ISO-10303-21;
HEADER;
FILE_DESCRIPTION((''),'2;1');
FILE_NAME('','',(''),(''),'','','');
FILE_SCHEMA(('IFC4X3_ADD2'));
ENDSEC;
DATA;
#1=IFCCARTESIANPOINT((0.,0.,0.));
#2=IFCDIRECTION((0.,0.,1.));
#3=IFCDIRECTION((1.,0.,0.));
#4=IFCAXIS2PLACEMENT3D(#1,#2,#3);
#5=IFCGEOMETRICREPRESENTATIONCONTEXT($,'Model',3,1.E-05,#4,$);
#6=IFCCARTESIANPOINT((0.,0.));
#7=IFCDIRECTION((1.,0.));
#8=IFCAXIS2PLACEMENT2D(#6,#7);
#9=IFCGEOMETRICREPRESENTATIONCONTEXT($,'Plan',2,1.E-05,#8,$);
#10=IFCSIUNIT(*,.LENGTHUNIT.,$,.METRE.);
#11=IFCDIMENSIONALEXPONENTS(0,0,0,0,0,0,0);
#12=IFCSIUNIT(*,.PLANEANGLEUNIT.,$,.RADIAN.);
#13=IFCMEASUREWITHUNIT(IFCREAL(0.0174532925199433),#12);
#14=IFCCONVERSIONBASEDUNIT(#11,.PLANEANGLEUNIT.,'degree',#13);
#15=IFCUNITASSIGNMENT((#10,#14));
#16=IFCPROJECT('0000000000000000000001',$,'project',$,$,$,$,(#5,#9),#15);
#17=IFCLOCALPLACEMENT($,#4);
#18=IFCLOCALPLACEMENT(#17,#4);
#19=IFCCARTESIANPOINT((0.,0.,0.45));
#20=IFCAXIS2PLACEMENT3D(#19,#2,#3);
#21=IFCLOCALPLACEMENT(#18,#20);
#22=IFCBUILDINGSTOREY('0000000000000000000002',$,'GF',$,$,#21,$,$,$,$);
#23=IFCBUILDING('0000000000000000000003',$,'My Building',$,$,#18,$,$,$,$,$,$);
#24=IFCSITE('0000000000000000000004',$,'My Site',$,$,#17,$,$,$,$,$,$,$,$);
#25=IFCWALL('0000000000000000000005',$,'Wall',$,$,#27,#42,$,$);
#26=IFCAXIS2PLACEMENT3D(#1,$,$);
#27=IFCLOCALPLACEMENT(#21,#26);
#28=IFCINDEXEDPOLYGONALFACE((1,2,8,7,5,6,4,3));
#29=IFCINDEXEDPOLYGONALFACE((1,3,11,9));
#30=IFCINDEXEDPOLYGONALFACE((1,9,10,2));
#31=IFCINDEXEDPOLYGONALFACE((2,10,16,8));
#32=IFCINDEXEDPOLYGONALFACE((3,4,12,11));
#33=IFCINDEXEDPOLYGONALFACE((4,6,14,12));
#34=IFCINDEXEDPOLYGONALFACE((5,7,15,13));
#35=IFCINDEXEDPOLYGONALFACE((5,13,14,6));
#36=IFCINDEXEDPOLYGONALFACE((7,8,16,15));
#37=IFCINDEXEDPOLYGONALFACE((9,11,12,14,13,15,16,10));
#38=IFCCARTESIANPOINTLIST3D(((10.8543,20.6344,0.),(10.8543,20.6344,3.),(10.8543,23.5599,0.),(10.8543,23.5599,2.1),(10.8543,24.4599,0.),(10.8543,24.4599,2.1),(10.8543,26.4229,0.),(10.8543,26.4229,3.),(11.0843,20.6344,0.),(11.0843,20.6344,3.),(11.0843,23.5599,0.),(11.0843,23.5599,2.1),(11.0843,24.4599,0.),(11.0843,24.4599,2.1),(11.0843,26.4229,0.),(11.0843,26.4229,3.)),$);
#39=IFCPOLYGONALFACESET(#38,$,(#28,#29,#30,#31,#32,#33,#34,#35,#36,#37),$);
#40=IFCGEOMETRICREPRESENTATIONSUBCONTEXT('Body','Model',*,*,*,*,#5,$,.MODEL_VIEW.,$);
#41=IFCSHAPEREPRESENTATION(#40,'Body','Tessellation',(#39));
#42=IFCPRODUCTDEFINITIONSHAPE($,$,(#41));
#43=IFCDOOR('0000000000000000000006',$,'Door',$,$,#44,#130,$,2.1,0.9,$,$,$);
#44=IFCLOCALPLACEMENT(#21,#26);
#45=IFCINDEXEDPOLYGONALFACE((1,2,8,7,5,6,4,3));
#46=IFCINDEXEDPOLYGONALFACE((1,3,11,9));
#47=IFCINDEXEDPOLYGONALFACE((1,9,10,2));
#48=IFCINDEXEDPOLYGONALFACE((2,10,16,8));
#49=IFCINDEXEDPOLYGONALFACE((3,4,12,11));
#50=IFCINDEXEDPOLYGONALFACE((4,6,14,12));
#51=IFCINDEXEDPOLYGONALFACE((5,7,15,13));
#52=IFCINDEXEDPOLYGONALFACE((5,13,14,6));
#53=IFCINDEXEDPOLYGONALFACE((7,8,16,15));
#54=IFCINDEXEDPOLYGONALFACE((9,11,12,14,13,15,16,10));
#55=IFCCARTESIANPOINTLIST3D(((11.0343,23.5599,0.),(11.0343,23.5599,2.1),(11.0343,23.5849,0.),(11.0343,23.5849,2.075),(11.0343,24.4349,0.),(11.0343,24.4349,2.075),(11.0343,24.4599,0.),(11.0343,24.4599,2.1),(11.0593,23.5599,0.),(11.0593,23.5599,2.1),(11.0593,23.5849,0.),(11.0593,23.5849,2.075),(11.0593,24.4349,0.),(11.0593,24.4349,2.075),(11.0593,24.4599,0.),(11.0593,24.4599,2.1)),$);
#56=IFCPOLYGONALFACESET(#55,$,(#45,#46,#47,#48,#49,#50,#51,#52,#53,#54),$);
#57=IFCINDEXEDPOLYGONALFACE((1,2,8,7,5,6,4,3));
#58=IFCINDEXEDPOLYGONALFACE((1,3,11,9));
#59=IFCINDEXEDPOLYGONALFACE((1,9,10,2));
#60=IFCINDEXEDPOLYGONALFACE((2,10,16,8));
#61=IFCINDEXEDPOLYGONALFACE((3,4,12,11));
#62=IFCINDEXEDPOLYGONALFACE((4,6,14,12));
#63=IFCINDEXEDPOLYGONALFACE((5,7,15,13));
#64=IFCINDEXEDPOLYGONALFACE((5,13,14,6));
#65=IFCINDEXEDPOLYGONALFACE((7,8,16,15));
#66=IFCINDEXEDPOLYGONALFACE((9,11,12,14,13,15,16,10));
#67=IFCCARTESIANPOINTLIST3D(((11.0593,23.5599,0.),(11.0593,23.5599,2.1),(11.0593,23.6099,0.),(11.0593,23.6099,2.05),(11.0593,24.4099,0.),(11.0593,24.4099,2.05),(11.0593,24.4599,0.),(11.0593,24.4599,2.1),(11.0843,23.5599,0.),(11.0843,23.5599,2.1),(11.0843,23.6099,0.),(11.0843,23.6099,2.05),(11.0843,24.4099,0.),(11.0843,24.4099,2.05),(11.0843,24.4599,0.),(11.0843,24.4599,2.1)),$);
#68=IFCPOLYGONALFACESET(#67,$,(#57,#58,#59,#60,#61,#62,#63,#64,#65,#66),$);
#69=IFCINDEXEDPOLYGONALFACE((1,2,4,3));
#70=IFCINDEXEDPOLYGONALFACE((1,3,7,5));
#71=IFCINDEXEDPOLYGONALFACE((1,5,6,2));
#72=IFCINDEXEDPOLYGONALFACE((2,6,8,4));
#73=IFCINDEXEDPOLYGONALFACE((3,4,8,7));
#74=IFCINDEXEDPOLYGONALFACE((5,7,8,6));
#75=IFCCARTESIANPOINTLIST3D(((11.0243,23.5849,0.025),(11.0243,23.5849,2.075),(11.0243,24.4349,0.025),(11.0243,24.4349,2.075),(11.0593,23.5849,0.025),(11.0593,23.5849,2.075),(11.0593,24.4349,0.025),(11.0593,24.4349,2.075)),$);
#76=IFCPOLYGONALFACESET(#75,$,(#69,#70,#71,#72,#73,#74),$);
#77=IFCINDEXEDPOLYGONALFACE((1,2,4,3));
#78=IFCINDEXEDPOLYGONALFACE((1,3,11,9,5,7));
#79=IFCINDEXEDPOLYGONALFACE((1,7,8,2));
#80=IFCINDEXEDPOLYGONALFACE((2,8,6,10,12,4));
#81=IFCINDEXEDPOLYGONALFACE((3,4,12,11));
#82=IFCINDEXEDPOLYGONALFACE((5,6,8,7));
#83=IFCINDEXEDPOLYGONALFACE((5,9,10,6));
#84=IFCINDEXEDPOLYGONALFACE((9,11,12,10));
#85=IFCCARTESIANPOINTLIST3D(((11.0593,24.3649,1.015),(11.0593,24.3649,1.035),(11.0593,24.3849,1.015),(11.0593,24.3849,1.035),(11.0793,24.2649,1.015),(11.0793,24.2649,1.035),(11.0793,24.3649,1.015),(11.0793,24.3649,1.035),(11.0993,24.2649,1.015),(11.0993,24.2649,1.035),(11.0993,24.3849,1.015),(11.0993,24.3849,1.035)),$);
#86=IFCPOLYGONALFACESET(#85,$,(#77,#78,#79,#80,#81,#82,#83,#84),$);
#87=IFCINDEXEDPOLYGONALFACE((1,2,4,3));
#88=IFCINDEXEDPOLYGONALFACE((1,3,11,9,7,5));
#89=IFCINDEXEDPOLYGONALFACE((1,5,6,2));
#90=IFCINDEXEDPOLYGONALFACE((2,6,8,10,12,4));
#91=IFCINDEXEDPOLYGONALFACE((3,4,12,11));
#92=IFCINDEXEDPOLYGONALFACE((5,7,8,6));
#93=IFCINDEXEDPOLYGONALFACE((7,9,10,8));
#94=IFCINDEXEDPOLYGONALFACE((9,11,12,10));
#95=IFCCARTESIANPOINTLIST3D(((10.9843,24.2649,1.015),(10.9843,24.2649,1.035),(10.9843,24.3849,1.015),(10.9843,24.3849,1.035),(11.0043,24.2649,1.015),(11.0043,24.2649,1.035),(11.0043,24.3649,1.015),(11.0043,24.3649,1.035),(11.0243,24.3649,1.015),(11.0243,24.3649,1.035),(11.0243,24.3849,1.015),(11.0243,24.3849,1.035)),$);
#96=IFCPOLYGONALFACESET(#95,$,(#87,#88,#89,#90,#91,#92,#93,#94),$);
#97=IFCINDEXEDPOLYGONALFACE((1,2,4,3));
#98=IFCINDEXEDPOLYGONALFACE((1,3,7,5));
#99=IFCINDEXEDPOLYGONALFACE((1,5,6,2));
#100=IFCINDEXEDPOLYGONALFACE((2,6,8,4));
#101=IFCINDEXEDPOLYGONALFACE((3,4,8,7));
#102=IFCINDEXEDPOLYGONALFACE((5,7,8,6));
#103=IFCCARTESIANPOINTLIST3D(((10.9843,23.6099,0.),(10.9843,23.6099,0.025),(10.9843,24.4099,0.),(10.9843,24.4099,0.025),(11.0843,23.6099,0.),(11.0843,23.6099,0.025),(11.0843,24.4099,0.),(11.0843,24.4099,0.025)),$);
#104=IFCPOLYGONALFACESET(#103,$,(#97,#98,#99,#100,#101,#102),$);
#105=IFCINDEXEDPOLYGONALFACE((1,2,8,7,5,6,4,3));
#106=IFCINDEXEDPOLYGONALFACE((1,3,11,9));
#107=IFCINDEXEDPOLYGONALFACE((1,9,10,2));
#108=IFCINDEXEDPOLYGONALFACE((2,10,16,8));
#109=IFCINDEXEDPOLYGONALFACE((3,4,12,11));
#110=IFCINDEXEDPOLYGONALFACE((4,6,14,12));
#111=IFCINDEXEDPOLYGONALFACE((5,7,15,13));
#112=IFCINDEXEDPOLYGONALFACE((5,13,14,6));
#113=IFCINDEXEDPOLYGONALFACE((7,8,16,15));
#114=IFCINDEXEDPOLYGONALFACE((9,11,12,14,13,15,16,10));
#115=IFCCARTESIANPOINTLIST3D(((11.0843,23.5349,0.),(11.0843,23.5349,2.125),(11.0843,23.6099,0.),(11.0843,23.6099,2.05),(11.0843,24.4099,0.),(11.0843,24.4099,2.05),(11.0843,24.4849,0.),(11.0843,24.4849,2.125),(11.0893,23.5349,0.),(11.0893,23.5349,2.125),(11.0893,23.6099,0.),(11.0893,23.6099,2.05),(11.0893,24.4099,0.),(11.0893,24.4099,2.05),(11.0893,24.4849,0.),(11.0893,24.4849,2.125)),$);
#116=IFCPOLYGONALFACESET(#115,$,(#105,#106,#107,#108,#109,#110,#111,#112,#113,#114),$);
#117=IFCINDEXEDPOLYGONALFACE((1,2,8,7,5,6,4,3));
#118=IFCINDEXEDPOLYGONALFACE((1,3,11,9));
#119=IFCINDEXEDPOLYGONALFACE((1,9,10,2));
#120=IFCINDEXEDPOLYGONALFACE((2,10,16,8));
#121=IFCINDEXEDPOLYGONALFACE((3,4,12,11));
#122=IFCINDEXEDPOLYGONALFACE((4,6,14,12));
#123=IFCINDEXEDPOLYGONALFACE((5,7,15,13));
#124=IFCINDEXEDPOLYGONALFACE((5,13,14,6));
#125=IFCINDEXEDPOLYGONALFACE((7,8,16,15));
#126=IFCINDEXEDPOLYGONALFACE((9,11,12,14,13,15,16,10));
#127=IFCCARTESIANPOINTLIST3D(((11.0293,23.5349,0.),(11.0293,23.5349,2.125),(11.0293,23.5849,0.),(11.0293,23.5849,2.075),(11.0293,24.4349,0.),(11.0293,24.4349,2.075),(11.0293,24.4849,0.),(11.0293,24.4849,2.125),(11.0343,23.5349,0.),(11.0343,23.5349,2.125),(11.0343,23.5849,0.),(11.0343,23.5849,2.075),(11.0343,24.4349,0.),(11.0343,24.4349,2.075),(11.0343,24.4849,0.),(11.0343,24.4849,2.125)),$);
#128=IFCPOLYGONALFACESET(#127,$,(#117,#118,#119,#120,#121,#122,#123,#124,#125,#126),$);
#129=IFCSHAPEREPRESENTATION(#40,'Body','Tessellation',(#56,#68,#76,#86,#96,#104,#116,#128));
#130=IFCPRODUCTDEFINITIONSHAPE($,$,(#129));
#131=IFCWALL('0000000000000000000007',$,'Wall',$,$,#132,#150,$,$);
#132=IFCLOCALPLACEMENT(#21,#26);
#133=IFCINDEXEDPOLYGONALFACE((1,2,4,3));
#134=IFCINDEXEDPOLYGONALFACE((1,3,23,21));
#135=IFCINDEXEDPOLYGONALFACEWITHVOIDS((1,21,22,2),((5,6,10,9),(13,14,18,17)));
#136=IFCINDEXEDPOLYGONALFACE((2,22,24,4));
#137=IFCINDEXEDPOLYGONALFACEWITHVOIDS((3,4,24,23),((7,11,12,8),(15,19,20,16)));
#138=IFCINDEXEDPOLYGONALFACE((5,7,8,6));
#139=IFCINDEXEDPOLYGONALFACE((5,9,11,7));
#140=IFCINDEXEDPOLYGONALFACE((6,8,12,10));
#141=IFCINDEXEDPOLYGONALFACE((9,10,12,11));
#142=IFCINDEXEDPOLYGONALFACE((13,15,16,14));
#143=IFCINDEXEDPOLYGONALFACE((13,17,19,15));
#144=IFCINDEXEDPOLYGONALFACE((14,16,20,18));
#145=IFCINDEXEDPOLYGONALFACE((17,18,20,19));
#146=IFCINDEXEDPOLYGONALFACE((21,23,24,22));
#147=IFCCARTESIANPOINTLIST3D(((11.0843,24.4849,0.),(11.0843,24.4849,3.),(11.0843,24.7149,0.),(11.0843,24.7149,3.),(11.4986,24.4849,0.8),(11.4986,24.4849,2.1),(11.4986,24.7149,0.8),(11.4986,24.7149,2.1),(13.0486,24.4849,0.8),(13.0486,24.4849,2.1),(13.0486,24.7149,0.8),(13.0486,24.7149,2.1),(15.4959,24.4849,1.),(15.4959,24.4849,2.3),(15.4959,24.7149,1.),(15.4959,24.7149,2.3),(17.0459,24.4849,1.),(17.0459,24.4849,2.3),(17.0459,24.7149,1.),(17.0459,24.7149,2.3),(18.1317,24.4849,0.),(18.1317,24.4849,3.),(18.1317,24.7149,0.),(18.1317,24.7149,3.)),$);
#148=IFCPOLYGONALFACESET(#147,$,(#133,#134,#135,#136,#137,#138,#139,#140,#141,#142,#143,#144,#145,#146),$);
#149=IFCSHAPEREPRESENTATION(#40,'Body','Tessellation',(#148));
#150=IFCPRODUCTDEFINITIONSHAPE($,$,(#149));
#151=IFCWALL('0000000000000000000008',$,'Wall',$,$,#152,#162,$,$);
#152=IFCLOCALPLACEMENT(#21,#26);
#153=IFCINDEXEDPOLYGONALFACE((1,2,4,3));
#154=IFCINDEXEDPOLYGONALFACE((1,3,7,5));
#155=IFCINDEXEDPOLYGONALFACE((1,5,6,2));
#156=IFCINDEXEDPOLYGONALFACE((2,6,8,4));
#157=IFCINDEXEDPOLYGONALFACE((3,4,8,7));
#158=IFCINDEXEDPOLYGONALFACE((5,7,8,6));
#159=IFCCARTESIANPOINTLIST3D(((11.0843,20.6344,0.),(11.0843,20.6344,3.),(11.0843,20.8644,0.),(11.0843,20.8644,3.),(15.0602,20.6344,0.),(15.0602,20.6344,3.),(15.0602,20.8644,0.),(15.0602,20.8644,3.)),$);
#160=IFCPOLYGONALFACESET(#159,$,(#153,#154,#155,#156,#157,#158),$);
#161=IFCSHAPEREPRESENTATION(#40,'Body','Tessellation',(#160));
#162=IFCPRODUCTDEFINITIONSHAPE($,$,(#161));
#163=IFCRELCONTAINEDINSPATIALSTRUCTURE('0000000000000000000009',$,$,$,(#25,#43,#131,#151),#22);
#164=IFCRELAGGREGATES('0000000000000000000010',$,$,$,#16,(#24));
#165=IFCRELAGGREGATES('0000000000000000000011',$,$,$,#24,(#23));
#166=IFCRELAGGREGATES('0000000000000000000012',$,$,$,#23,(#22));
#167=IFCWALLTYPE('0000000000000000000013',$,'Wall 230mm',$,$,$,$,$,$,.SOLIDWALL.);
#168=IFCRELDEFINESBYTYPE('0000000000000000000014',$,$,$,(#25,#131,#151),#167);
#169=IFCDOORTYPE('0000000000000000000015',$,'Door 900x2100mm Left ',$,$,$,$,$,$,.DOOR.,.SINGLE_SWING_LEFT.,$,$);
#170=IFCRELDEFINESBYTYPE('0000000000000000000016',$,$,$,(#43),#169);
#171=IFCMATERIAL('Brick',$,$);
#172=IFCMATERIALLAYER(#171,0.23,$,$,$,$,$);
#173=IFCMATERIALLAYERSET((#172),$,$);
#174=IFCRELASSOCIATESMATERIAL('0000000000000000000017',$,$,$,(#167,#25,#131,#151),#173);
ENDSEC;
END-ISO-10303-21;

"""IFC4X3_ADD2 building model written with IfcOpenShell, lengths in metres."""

from ifc_helpers import new_model, entity, si_unit, converted_unit, frame, origin_with_axes, origin_2d_with_axis, place, context, subcontext, project, spatial, line, indexed_curve, outline, extrude, shape, source, transform, mapped, material, layer, layer_set, layer_usage, type_object, type_shapes, element, fill, save


model = new_model("IFC4X3_ADD2")

# Units and contexts
model_context = context("Model", 3, precision=1e-05, world=origin_with_axes())
plan_context = context("Plan", 2, precision=1e-05, world=origin_2d_with_axis())
body_context_1 = subcontext(model_context, "Body", "Model", "MODEL_VIEW")
body_context_2 = subcontext(plan_context, "Body", "Plan", "PLAN_VIEW")
ifc_project = project(units=[si_unit("LENGTHUNIT", "METRE"), converted_unit("PLANEANGLEUNIT", "degree", entity("IfcReal", 0.0174532925199433), si_unit("PLANEANGLEUNIT", "RADIAN"), dimensions=[0, 0, 0, 0, 0, 0, 0])], contexts=[model_context, plan_context])

# Site, building, storey
site_placement = place(None, origin_with_axes())
site = spatial("IfcSite", under=ifc_project, at=site_placement, Name="My Site")
building_placement = place(site_placement, origin_with_axes())
building = spatial("IfcBuilding", under=site, at=building_placement, Name="My Building")
storey_placement = place(building_placement, frame((0.0, 0.0, 0.45), z_axis=(0.0, 0.0, 1.0), x_axis=(1.0, 0.0, 0.0)))
storey = spatial("IfcBuildingStorey", under=building, at=storey_placement, Name="GF")

# Shared definitions
ifc_material = material(Name="Brick")
ifc_layer_1 = layer(ifc_material, 0.23)
ifc_layer_set_1 = layer_set([ifc_layer_1])
wall_type_1 = type_object("IfcWallType", Name="Wall 230mm", PredefinedType="SOLIDWALL", material=ifc_layer_set_1)

# Shared definitions
shared_shape_1 = source(origin_with_axes(), body_context_1, "Body", "SweptSolid", [
    extrude(outline(indexed_curve([(0.0, 0.0), (1.55, 0.0), (1.55, 1.3), (0.0, 1.3)], segments=[line(1, 2, 3, 4, 1)])), frame((-0.775, -0.6, 0.0), z_axis=(0.0, -1.0, 0.0), x_axis=(1.0, 0.0, 0.0)), (0.0, 0.0, -1.0), 1.2),
])

# Wall, opening, door
ifc_layer_usage_1 = layer_usage(ifc_layer_set_1, "AXIS2", "POSITIVE", 0.0)
wall_1_placement = place(storey_placement, frame((11.0843, 20.6344, 0.0), z_axis=(0.0, 0.0, 1.0), x_axis=(0.0, 1.0, 0.0)))
wall_1 = element("IfcWall", 1, at=wall_1_placement, inside=storey, type_object=wall_type_1, material=ifc_layer_usage_1, Name="Wall", context=body_context_1, shape_type="SweptSolid", body=[
    extrude(outline(indexed_curve([(0.0, 0.0), (0.0, 0.23), (5.7885, 0.23), (5.7885, 0.0), (0.0, 0.0)], self_intersect=False)), origin_with_axes(), (0.0, 0.0, 1.0), 3.0),
])
shared_shape_2 = source(origin_with_axes(), body_context_1, "Body", "SweptSolid", [
    extrude(outline(indexed_curve([(0.0, 0.0), (0.9, 0.0), (0.9, 2.1), (0.0, 2.1)], segments=[line(1, 2, 3, 4, 1)])), frame((0.0, -0.6, 0.0), z_axis=(0.0, -1.0, 0.0), x_axis=(1.0, 0.0, 0.0)), (0.0, 0.0, -1.0), 1.2),
])
opening_1_placement = place(wall_1_placement, frame((2.9255, 0.0, 0.0), z_axis=(0.0, 0.0, 1.0), x_axis=(1.0, 0.0, 0.0)))
opening_1 = element("IfcOpeningElement", 2, at=opening_1_placement, cuts=wall_1, PredefinedType="OPENING", context=body_context_1, shape_type="MappedRepresentation", body=[
    mapped(shared_shape_2, transform((0.0, 0.0, 0.0), x_axis=(1.0, 0.0, 0.0), y_axis=(0.0, 1.0, 0.0), z_axis=(0.0, 0.0, 1.0), scale=1.0)),
])
door_type_1 = type_object("IfcDoorType", Name="Door 900x2100mm Left ", OperationType="SINGLE_SWING_LEFT", PredefinedType="DOOR")
shared_shape_3 = source(origin_with_axes(), body_context_1, "Body", "SweptSolid", [
    extrude(outline(indexed_curve([(0.0, 0.0), (0.0, 2.1), (0.9, 2.1), (0.9, 0.0), (0.875, 0.0), (0.875, 2.075), (0.025, 2.075), (0.025, 0.0)], segments=[line(1, 2, 3, 4, 5, 6, 7, 8, 1)])), frame((0.0, 0.025, 0.0), z_axis=(0.0, -1.0, 0.0), x_axis=(1.0, 0.0, 0.0)), (0.0, 0.0, -1.0), 0.025),
    extrude(outline(indexed_curve([(0.0, 0.0), (0.0, 2.1), (0.9, 2.1), (0.9, 0.0), (0.85, 0.0), (0.85, 2.05), (0.05, 2.05), (0.05, 0.0)], segments=[line(1, 2, 3, 4, 5, 6, 7, 8, 1)])), frame((0.0, 0.0, 0.0), z_axis=(0.0, -1.0, 0.0), x_axis=(1.0, 0.0, 0.0)), (0.0, 0.0, -1.0), 0.025),
    extrude(outline(indexed_curve([(0.0, 0.0), (0.85, 0.0), (0.85, 0.035), (0.0, 0.035)], segments=[line(1, 2, 3, 4, 1)])), frame((0.025, 0.025, 0.025), z_axis=(0.0, 0.0, 1.0), x_axis=(1.0, 0.0, 0.0)), (0.0, 0.0, 1.0), 2.05),
    extrude(outline(indexed_curve([(0.0, 0.0), (0.0, -0.04), (-0.12, -0.04), (-0.12, -0.02), (-0.02, -0.02), (-0.02, 0.0)], segments=[line(1, 2, 3, 4, 5, 6, 1)])), frame((0.825, 0.025, 1.015), z_axis=(0.0, 0.0, 1.0), x_axis=(1.0, 0.0, 0.0)), (0.0, 0.0, 1.0), 0.02),
    extrude(outline(indexed_curve([(0.0, 0.0), (0.0, 0.04), (-0.12, 0.04), (-0.12, 0.02), (-0.02, 0.02), (-0.02, 0.0)], segments=[line(1, 2, 3, 4, 5, 6, 1)])), frame((0.825, 0.06, 1.015), z_axis=(0.0, 0.0, 1.0), x_axis=(1.0, 0.0, 0.0)), (0.0, 0.0, 1.0), 0.02),
    extrude(outline(indexed_curve([(0.0, 0.0), (0.8, 0.0), (0.8, 0.1), (0.0, 0.1)], segments=[line(1, 2, 3, 4, 1)])), frame((0.05, 0.0, 0.0), z_axis=(0.0, 0.0, 1.0), x_axis=(1.0, 0.0, 0.0)), (0.0, 0.0, 1.0), 0.025),
    extrude(outline(indexed_curve([(0.0, 0.0), (0.0, 2.125), (0.95, 2.125), (0.95, 0.0), (0.875, 0.0), (0.875, 2.05), (0.075, 2.05), (0.075, 0.0)], segments=[line(1, 2, 3, 4, 5, 6, 7, 8, 1)])), frame((-0.025, -0.005, 0.0), z_axis=(0.0, -1.0, 0.0), x_axis=(1.0, 0.0, 0.0)), (0.0, 0.0, -1.0), 0.005),
    extrude(outline(indexed_curve([(0.0, 0.0), (0.0, 2.125), (0.95, 2.125), (0.95, 0.0), (0.9, 0.0), (0.9, 2.075), (0.05, 2.075), (0.05, 0.0)], segments=[line(1, 2, 3, 4, 5, 6, 7, 8, 1)])), frame((-0.025, 0.05, 0.0), z_axis=(0.0, -1.0, 0.0), x_axis=(1.0, 0.0, 0.0)), (0.0, 0.0, -1.0), 0.005),
])
shared_shape_4 = source(origin_with_axes(), body_context_2, "Body", "Curve2D", [
    entity("IfcIndexedPolyCurve", entity("IfcCartesianPointList2D", [[0.0, 0.0], [0.0, 0.05], [0.025, 0.05], [0.025, 0.025], [0.05, 0.025], [0.05, 0.0]]), [entity("IfcLineIndex", [1, 2, 3, 4, 5, 6, 1])]),
    entity("IfcIndexedPolyCurve", entity("IfcCartesianPointList2D", [[0.9, 0.0], [0.9, 0.05], [0.875, 0.05], [0.875, 0.025], [0.85, 0.025], [0.85, 0.0]]), [entity("IfcLineIndex", [1, 2, 3, 4, 5, 6, 1])]),
    entity("IfcTrimmedCurve", entity("IfcEllipse", entity("IfcAxis2Placement2D", entity("IfcCartesianPoint", [0.06, 0.05]), entity("IfcDirection", [1.0, 0.0])), 0.815, 0.85), [entity("IfcCartesianPoint", [0.875, 0.05])], [entity("IfcCartesianPoint", [0.06, 0.9])], True, "CARTESIAN"),
    entity("IfcIndexedPolyCurve", entity("IfcCartesianPointList2D", [[0.025, 0.05], [0.06, 0.05], [0.06, 0.9], [0.025, 0.9]]), [entity("IfcLineIndex", [1, 2, 3, 4, 1])]),
])
type_shapes(door_type_1, [shared_shape_3, shared_shape_4])
door_1_placement = place(opening_1_placement, origin_with_axes())
door_1 = element("IfcDoor", 3, at=door_1_placement, inside=storey, type_object=door_type_1, Name="Door", OverallHeight=2.1, OverallWidth=0.9, shapes=[
    shape(body_context_1, "Body", "MappedRepresentation", [mapped(shared_shape_3, transform((0.0, 0.0, 0.0), x_axis=(1.0, 0.0, 0.0), y_axis=(0.0, 1.0, 0.0), z_axis=(0.0, 0.0, 1.0), scale=1.0))]),
    shape(body_context_2, "Body", "MappedRepresentation", [mapped(shared_shape_4, transform((0.0, 0.0, 0.0), x_axis=(1.0, 0.0, 0.0), y_axis=(0.0, 1.0, 0.0), z_axis=(0.0, 0.0, 1.0), scale=1.0))]),
])
fill(opening_1, door_1)

# Wall, openings
ifc_layer_usage_2 = layer_usage(ifc_layer_set_1, "AXIS2", "POSITIVE", 0.0)
wall_2_placement = place(storey_placement, frame((11.0843, 24.4849, 0.0), z_axis=(0.0, 0.0, 1.0), x_axis=(1.0, 0.0, 0.0)))
wall_2 = element("IfcWall", 4, at=wall_2_placement, inside=storey, type_object=wall_type_1, material=ifc_layer_usage_2, Name="Wall", context=body_context_1, shape_type="SweptSolid", body=[
    extrude(outline(indexed_curve([(0.0, 0.0), (0.0, 0.23), (7.0474, 0.23), (7.0474, 0.0), (0.0, 0.0)], self_intersect=False)), origin_with_axes(), (0.0, 0.0, 1.0), 3.0),
])
opening_2_placement = place(wall_2_placement, frame((5.1866, 0.2, 1.0), z_axis=(0.0, 0.0, 1.0), x_axis=(-1.0, 0.0, 0.0)))
element("IfcOpeningElement", 5, at=opening_2_placement, cuts=wall_2, PredefinedType="OPENING", context=body_context_1, shape_type="MappedRepresentation", body=[
    mapped(shared_shape_1, transform((0.0, 0.0, 0.0), x_axis=(1.0, 0.0, 0.0), y_axis=(0.0, 1.0, 0.0), z_axis=(0.0, 0.0, 1.0), scale=1.0)),
])
opening_3_placement = place(wall_2_placement, frame((1.1893, 0.0, 0.8), z_axis=(0.0, 0.0, 1.0), x_axis=(1.0, 0.0, 0.0)))
element("IfcOpeningElement", 6, at=opening_3_placement, cuts=wall_2, PredefinedType="OPENING", context=body_context_1, shape_type="MappedRepresentation", body=[
    mapped(shared_shape_1, transform((0.0, 0.0, 0.0), x_axis=(1.0, 0.0, 0.0), y_axis=(0.0, 1.0, 0.0), z_axis=(0.0, 0.0, 1.0), scale=1.0)),
])

# Wall
ifc_layer_usage_3 = layer_usage(ifc_layer_set_1, "AXIS2", "POSITIVE", 0.0)
wall_3_placement = place(storey_placement, frame((11.0843, 20.6344, 0.0), z_axis=(0.0, 0.0, 1.0), x_axis=(1.0, 0.0, 0.0)))
element("IfcWall", 7, at=wall_3_placement, inside=storey, type_object=wall_type_1, material=ifc_layer_usage_3, Name="Wall", context=body_context_1, shape_type="SweptSolid", body=[
    extrude(outline(indexed_curve([(0.0, 0.0), (0.0, 0.23), (3.9759, 0.23), (3.9759, 0.0), (0.0, 0.0)], self_intersect=False)), origin_with_axes(), (0.0, 0.0, 1.0), 3.0),
])

save(model, "model.ifc")
